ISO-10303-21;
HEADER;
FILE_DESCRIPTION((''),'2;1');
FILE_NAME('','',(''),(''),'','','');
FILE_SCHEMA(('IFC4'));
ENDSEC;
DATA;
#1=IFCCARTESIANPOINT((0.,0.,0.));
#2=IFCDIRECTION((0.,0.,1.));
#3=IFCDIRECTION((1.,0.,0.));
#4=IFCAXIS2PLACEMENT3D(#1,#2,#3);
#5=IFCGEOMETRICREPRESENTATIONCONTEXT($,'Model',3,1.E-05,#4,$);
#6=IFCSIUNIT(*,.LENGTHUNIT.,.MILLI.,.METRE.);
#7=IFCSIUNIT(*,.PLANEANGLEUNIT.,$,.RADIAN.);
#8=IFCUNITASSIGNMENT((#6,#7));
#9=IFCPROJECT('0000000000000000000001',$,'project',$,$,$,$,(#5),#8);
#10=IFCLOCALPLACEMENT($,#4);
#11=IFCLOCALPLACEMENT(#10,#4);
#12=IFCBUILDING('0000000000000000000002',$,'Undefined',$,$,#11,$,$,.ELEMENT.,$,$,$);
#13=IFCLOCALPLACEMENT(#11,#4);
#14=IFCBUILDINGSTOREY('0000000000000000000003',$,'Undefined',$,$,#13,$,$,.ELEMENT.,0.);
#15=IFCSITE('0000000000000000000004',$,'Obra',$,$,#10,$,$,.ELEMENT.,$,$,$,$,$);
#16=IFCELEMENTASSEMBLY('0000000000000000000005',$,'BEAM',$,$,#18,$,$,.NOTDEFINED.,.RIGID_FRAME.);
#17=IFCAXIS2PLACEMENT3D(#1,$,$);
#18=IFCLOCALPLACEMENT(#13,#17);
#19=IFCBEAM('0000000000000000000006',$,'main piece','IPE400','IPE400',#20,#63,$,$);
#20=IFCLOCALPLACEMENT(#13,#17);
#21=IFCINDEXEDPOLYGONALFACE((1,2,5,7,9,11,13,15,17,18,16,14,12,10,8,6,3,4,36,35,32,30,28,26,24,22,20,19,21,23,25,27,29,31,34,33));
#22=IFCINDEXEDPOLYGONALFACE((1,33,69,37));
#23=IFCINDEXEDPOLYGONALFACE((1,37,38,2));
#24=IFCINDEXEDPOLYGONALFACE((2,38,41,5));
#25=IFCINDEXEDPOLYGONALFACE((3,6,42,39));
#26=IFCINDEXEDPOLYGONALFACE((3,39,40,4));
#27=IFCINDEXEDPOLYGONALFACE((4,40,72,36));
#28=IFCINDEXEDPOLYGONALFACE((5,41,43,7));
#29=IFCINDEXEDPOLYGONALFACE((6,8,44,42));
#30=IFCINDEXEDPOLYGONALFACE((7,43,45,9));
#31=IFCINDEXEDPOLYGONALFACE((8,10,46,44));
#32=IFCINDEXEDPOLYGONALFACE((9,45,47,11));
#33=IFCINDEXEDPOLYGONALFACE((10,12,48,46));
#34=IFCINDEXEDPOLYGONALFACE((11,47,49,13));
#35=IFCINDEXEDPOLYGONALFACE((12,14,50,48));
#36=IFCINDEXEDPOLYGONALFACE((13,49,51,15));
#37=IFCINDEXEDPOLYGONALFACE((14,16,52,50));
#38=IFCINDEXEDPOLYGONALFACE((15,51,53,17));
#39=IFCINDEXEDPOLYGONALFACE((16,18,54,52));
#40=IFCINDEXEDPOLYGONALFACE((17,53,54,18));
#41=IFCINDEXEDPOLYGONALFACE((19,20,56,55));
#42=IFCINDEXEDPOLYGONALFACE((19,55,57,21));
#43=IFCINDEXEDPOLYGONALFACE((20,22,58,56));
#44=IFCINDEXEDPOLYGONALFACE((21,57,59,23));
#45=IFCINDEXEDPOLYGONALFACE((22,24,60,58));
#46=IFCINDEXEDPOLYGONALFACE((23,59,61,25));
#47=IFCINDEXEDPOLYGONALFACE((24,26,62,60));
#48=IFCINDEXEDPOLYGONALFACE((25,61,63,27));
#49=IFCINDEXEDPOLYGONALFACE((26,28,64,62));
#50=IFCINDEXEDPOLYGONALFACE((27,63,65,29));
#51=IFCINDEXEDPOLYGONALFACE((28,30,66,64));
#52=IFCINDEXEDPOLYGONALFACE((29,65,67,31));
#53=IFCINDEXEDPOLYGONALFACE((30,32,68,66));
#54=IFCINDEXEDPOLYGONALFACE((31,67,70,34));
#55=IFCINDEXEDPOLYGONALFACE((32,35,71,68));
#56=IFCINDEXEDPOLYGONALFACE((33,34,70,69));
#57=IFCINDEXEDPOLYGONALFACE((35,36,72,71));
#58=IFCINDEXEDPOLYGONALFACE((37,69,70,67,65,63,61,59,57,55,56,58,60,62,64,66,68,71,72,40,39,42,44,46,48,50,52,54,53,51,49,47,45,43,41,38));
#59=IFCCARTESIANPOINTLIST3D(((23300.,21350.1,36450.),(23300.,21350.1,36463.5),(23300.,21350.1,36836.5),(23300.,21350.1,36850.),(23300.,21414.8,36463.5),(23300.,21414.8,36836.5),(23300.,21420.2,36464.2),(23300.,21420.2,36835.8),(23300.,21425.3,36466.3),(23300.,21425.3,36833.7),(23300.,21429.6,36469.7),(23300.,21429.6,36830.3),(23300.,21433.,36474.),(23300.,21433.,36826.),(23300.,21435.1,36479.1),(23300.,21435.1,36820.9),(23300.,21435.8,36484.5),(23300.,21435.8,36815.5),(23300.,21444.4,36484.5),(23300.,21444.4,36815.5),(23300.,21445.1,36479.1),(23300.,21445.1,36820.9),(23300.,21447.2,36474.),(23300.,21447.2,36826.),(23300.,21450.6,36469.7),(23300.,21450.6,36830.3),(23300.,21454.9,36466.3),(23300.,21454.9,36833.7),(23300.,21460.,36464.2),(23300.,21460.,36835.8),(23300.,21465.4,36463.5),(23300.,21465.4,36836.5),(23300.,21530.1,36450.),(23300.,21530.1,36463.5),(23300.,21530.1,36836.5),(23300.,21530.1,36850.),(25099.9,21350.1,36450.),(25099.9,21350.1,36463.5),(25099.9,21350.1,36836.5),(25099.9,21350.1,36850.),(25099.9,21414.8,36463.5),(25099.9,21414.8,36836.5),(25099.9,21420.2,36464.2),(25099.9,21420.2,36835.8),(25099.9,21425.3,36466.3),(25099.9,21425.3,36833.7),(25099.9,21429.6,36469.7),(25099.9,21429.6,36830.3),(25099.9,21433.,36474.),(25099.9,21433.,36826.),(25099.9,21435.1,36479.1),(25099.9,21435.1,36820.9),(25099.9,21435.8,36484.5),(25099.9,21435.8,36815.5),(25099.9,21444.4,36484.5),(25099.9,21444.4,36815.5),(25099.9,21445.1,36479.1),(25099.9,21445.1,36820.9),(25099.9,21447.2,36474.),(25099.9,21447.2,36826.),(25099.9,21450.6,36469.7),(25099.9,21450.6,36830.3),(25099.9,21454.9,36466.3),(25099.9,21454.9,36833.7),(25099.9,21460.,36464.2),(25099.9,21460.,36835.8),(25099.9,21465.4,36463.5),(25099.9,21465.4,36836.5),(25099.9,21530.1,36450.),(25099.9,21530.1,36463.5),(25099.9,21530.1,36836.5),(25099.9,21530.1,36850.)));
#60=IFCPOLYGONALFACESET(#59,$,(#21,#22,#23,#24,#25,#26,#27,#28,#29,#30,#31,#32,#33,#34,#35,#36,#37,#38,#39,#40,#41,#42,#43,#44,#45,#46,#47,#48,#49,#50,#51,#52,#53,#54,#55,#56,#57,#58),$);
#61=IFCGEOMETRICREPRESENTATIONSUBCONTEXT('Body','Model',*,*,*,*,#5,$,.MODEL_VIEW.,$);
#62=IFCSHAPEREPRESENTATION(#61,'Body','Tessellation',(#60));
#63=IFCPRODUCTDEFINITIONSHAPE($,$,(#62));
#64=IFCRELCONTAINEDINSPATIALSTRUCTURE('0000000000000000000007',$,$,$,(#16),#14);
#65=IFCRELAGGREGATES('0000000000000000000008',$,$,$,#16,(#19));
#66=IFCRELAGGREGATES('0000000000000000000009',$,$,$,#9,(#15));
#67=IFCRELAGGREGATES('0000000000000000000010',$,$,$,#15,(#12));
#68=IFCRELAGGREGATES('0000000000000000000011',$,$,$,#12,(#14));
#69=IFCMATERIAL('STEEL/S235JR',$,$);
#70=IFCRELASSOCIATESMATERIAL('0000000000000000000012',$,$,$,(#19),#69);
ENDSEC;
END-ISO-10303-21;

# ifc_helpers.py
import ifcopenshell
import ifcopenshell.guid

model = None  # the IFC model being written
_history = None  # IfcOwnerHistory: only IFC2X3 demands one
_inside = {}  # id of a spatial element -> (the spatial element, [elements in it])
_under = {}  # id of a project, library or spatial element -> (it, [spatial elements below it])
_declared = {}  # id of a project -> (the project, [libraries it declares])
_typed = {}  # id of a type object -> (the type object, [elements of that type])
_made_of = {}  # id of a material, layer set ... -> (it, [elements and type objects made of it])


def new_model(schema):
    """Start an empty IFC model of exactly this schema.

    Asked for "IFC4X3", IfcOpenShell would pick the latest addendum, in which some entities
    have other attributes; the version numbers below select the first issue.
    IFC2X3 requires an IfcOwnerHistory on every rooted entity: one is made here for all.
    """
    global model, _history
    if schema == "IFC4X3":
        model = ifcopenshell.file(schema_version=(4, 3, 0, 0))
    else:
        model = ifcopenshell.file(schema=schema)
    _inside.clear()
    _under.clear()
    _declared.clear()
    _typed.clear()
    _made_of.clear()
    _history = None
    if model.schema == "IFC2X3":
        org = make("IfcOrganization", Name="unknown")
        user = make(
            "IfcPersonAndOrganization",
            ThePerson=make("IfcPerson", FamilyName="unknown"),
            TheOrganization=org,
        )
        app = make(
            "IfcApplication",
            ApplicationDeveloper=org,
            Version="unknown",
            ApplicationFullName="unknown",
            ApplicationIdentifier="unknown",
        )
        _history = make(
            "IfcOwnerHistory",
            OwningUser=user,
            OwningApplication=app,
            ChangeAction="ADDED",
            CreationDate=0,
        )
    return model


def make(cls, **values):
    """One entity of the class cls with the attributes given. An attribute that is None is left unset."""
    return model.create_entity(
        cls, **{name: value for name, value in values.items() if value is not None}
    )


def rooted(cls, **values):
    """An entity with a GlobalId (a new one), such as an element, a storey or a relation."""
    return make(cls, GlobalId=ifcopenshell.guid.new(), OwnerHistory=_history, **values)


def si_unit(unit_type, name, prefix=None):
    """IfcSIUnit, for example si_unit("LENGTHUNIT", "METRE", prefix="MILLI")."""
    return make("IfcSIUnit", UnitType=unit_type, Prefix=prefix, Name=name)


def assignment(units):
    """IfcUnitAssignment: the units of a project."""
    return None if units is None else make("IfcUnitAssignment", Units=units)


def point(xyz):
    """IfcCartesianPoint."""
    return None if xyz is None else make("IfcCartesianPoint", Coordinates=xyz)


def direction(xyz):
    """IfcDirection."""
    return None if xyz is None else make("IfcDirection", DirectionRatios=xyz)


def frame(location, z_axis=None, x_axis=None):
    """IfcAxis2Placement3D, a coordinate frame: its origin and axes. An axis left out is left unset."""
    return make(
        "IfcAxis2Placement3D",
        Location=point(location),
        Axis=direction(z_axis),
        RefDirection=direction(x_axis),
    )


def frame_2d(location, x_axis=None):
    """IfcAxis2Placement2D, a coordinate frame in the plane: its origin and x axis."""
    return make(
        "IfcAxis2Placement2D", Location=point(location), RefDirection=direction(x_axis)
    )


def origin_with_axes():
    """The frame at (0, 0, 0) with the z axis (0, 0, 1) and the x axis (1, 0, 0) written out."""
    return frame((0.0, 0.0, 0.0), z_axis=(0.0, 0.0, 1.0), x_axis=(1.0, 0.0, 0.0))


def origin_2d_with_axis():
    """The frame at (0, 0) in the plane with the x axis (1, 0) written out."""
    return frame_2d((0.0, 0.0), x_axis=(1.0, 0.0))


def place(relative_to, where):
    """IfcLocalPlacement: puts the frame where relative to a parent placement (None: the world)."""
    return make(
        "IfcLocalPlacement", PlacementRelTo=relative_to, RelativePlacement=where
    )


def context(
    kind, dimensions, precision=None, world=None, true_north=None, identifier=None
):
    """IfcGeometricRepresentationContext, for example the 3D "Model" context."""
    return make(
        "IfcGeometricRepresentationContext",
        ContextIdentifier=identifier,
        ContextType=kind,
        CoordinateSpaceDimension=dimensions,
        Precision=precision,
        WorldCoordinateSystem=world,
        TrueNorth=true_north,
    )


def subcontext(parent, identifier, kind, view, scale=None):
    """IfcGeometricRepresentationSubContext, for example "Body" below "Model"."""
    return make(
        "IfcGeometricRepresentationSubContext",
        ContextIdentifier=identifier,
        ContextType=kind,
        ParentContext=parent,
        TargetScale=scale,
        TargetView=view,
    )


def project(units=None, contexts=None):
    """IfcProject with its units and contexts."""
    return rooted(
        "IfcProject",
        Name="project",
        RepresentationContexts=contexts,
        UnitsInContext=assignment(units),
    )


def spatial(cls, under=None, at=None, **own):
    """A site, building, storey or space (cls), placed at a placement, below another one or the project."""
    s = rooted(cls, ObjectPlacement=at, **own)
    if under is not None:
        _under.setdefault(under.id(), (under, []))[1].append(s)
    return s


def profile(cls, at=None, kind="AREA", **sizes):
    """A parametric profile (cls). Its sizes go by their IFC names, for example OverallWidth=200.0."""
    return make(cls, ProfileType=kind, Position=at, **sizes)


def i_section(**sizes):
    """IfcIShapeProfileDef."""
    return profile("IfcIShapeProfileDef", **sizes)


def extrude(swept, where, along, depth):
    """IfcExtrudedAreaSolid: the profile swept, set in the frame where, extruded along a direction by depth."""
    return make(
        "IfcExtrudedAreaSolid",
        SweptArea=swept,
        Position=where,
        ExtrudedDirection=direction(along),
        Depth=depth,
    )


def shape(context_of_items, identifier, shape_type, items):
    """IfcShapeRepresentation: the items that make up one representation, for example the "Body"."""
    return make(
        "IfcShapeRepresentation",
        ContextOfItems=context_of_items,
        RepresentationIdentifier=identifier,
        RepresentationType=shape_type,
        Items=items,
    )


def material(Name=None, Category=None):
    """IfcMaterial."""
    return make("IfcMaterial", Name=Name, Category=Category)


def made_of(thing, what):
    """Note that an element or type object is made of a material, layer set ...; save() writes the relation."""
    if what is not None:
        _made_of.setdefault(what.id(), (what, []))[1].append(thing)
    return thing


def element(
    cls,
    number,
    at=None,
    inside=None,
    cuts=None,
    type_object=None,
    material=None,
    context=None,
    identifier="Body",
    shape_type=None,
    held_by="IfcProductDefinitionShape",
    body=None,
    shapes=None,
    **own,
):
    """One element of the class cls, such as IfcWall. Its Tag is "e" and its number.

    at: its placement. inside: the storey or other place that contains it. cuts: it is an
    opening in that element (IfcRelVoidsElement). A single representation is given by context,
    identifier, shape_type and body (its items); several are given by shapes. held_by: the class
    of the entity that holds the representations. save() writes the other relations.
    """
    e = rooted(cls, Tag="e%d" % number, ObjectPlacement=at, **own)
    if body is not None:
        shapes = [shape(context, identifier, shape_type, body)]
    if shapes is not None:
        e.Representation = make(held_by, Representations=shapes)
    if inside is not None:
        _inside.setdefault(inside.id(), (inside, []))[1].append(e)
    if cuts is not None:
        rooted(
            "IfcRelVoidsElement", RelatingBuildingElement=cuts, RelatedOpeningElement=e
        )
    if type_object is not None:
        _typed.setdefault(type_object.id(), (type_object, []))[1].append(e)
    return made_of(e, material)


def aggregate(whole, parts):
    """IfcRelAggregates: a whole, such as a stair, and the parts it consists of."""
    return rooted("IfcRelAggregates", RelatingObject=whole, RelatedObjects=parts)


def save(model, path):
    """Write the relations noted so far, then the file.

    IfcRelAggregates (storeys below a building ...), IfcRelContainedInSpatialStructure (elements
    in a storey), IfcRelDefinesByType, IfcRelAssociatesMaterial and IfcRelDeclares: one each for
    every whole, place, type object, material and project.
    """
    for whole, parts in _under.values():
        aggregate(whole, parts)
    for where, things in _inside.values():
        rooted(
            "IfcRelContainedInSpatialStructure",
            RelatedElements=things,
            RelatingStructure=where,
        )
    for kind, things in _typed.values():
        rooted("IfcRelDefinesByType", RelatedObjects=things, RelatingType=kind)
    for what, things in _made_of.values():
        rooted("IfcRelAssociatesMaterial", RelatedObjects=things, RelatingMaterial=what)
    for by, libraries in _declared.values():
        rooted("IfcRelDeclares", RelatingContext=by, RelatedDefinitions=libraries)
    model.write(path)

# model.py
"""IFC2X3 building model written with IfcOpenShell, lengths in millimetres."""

from ifc_helpers import new_model, si_unit, frame, origin_with_axes, origin_2d_with_axis, place, context, subcontext, project, spatial, i_section, extrude, material, element, aggregate, save


model = new_model("IFC2X3")

# Units and contexts
model_context = context("Model", 3, precision=1e-05, world=origin_with_axes())
body_context = subcontext(model_context, "Body", "Model", "MODEL_VIEW")
ifc_project = project(units=[si_unit("LENGTHUNIT", "METRE", prefix="MILLI"), si_unit("PLANEANGLEUNIT", "RADIAN")], contexts=[model_context])

# Site, building, storey
site_placement = place(None, origin_with_axes())
site = spatial("IfcSite", under=ifc_project, at=site_placement, Name="Obra", CompositionType="ELEMENT")
building_placement = place(site_placement, origin_with_axes())
building = spatial("IfcBuilding", under=site, at=building_placement, Name="Undefined", CompositionType="ELEMENT")
storey_placement = place(building_placement, origin_with_axes())
storey = spatial("IfcBuildingStorey", under=building, at=storey_placement, Name="Undefined", CompositionType="ELEMENT", Elevation=0.0)

# Element assembly, beam
ifc_material_1 = material(Name="STEEL/S235JR")
assembly_1_placement = place(storey_placement, origin_with_axes())
assembly_1 = element("IfcElementAssembly", 1, at=assembly_1_placement, inside=storey, Name="BEAM", AssemblyPlace="NOTDEFINED", PredefinedType="RIGID_FRAME")
beam_1_placement = place(assembly_1_placement, frame((25100.0, 21440.1, 36650.0), z_axis=(0.0, 0.0, 1.0), x_axis=(-1.0, 0.0, 0.0)))
beam_1 = element("IfcBeam", 2, at=beam_1_placement, material=ifc_material_1, Name="main piece", Description="IPE400", ObjectType="IPE400", context=body_context, shape_type="SweptSolid", body=[
    extrude(i_section(OverallWidth=180.0, OverallDepth=400.0, WebThickness=8.6, FlangeThickness=13.5, FilletRadius=21.0, at=origin_2d_with_axis()), frame((1800.0, 0.0, 0.0), z_axis=(-1.0, 0.0, 0.0), x_axis=(0.0, -1.0, 0.0)), (0.0, 0.0, 1.0), 1800.0),
])
aggregate(assembly_1, [beam_1])

save(model, "model.ifc")
